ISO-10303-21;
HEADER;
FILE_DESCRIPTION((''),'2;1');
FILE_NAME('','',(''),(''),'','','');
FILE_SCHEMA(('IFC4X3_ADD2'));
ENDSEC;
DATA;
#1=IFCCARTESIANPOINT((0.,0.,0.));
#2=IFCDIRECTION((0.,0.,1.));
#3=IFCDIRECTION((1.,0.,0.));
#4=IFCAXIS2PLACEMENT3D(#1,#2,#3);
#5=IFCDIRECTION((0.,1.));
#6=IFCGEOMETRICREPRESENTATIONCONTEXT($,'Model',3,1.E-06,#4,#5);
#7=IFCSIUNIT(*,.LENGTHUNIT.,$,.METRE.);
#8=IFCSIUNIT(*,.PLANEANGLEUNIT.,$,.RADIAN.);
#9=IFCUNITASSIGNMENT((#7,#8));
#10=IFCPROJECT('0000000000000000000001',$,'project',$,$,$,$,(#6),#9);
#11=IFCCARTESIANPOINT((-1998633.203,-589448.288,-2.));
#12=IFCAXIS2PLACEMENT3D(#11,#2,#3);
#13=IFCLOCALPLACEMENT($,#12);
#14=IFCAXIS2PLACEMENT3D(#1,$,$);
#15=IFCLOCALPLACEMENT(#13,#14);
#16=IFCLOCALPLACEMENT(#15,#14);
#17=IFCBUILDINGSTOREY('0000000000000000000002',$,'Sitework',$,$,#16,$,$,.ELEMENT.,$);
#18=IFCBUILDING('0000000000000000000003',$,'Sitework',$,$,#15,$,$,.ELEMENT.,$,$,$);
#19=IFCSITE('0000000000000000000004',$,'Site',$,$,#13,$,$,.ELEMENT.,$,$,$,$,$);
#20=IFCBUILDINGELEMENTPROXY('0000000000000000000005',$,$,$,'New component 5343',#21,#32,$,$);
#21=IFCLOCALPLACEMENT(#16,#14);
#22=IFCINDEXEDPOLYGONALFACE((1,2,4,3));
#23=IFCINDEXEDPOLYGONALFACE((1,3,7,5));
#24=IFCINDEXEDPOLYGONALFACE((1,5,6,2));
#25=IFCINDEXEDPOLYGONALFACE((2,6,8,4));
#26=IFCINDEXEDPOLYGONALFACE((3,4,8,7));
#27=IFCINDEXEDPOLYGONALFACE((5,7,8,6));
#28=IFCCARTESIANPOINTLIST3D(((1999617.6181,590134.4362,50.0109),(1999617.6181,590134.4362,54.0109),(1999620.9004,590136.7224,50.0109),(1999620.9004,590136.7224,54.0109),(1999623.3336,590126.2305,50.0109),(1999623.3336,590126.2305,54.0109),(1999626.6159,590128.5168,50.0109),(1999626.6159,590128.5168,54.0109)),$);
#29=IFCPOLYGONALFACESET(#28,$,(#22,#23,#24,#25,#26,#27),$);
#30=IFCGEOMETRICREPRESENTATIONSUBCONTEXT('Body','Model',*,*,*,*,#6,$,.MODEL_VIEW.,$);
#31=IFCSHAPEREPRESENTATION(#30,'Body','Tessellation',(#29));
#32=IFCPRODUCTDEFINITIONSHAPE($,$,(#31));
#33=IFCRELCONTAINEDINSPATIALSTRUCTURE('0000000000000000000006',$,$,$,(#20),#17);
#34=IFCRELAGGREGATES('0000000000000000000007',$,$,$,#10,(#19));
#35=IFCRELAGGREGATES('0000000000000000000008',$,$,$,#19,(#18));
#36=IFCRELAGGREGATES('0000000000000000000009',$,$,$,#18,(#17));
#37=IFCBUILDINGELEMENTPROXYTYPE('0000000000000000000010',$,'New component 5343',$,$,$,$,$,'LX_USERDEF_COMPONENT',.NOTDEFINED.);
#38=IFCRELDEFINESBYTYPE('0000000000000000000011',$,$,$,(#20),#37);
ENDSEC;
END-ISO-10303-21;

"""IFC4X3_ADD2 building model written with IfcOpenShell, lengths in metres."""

from ifc_helpers import new_model, si_unit, direction, frame, frame_2d, origin, origin_with_axes, place, context, subcontext, project, spatial, rectangle, extrude, type_object, element, save


model = new_model("IFC4X3_ADD2")

# Units and contexts
model_context = context("Model", 3, precision=1e-06, world=origin_with_axes(), true_north=direction((0.0, 1.0)))
body_context = subcontext(model_context, "Body", "Model", "MODEL_VIEW")
ifc_project = project(units=[si_unit("LENGTHUNIT", "METRE"), si_unit("PLANEANGLEUNIT", "RADIAN")], contexts=[model_context])

# Site, building, storey
site_placement = place(None, frame((-1998633.203, -589448.288, -2.0), z_axis=(0.0, 0.0, 1.0), x_axis=(1.0, 0.0, 0.0)))
site = spatial("IfcSite", under=ifc_project, at=site_placement, Name="Site", CompositionType="ELEMENT")
building_placement = place(site_placement, origin())
building = spatial("IfcBuilding", under=site, at=building_placement, Name="Sitework", CompositionType="ELEMENT")
storey_placement = place(building_placement, origin())
storey = spatial("IfcBuildingStorey", under=building, at=storey_placement, Name="Sitework", CompositionType="ELEMENT")

# Building element proxy
building_element_proxy_type = type_object("IfcBuildingElementProxyType", Name="New component 5343", ElementType="LX_USERDEF_COMPONENT", PredefinedType="NOTDEFINED")
proxy_placement = place(storey_placement, frame((1999617.6181, 590134.4362, 50.0109), z_axis=(0.0, 0.0, 1.0), x_axis=(0.571553, -0.820565, 0.0)))
element("IfcBuildingElementProxy", 1, at=proxy_placement, inside=storey, type_object=building_element_proxy_type, ObjectType="New component 5343", context=body_context, shape_type="SweptSolid", body=[
    extrude(rectangle(XDim=10.0, YDim=4.0, at=frame_2d((5.0, 2.0), x_axis=(1.0, 0.0))), origin_with_axes(), (0.0, 0.0, 1.0), 4.0),
])

save(model, "model.ifc")
